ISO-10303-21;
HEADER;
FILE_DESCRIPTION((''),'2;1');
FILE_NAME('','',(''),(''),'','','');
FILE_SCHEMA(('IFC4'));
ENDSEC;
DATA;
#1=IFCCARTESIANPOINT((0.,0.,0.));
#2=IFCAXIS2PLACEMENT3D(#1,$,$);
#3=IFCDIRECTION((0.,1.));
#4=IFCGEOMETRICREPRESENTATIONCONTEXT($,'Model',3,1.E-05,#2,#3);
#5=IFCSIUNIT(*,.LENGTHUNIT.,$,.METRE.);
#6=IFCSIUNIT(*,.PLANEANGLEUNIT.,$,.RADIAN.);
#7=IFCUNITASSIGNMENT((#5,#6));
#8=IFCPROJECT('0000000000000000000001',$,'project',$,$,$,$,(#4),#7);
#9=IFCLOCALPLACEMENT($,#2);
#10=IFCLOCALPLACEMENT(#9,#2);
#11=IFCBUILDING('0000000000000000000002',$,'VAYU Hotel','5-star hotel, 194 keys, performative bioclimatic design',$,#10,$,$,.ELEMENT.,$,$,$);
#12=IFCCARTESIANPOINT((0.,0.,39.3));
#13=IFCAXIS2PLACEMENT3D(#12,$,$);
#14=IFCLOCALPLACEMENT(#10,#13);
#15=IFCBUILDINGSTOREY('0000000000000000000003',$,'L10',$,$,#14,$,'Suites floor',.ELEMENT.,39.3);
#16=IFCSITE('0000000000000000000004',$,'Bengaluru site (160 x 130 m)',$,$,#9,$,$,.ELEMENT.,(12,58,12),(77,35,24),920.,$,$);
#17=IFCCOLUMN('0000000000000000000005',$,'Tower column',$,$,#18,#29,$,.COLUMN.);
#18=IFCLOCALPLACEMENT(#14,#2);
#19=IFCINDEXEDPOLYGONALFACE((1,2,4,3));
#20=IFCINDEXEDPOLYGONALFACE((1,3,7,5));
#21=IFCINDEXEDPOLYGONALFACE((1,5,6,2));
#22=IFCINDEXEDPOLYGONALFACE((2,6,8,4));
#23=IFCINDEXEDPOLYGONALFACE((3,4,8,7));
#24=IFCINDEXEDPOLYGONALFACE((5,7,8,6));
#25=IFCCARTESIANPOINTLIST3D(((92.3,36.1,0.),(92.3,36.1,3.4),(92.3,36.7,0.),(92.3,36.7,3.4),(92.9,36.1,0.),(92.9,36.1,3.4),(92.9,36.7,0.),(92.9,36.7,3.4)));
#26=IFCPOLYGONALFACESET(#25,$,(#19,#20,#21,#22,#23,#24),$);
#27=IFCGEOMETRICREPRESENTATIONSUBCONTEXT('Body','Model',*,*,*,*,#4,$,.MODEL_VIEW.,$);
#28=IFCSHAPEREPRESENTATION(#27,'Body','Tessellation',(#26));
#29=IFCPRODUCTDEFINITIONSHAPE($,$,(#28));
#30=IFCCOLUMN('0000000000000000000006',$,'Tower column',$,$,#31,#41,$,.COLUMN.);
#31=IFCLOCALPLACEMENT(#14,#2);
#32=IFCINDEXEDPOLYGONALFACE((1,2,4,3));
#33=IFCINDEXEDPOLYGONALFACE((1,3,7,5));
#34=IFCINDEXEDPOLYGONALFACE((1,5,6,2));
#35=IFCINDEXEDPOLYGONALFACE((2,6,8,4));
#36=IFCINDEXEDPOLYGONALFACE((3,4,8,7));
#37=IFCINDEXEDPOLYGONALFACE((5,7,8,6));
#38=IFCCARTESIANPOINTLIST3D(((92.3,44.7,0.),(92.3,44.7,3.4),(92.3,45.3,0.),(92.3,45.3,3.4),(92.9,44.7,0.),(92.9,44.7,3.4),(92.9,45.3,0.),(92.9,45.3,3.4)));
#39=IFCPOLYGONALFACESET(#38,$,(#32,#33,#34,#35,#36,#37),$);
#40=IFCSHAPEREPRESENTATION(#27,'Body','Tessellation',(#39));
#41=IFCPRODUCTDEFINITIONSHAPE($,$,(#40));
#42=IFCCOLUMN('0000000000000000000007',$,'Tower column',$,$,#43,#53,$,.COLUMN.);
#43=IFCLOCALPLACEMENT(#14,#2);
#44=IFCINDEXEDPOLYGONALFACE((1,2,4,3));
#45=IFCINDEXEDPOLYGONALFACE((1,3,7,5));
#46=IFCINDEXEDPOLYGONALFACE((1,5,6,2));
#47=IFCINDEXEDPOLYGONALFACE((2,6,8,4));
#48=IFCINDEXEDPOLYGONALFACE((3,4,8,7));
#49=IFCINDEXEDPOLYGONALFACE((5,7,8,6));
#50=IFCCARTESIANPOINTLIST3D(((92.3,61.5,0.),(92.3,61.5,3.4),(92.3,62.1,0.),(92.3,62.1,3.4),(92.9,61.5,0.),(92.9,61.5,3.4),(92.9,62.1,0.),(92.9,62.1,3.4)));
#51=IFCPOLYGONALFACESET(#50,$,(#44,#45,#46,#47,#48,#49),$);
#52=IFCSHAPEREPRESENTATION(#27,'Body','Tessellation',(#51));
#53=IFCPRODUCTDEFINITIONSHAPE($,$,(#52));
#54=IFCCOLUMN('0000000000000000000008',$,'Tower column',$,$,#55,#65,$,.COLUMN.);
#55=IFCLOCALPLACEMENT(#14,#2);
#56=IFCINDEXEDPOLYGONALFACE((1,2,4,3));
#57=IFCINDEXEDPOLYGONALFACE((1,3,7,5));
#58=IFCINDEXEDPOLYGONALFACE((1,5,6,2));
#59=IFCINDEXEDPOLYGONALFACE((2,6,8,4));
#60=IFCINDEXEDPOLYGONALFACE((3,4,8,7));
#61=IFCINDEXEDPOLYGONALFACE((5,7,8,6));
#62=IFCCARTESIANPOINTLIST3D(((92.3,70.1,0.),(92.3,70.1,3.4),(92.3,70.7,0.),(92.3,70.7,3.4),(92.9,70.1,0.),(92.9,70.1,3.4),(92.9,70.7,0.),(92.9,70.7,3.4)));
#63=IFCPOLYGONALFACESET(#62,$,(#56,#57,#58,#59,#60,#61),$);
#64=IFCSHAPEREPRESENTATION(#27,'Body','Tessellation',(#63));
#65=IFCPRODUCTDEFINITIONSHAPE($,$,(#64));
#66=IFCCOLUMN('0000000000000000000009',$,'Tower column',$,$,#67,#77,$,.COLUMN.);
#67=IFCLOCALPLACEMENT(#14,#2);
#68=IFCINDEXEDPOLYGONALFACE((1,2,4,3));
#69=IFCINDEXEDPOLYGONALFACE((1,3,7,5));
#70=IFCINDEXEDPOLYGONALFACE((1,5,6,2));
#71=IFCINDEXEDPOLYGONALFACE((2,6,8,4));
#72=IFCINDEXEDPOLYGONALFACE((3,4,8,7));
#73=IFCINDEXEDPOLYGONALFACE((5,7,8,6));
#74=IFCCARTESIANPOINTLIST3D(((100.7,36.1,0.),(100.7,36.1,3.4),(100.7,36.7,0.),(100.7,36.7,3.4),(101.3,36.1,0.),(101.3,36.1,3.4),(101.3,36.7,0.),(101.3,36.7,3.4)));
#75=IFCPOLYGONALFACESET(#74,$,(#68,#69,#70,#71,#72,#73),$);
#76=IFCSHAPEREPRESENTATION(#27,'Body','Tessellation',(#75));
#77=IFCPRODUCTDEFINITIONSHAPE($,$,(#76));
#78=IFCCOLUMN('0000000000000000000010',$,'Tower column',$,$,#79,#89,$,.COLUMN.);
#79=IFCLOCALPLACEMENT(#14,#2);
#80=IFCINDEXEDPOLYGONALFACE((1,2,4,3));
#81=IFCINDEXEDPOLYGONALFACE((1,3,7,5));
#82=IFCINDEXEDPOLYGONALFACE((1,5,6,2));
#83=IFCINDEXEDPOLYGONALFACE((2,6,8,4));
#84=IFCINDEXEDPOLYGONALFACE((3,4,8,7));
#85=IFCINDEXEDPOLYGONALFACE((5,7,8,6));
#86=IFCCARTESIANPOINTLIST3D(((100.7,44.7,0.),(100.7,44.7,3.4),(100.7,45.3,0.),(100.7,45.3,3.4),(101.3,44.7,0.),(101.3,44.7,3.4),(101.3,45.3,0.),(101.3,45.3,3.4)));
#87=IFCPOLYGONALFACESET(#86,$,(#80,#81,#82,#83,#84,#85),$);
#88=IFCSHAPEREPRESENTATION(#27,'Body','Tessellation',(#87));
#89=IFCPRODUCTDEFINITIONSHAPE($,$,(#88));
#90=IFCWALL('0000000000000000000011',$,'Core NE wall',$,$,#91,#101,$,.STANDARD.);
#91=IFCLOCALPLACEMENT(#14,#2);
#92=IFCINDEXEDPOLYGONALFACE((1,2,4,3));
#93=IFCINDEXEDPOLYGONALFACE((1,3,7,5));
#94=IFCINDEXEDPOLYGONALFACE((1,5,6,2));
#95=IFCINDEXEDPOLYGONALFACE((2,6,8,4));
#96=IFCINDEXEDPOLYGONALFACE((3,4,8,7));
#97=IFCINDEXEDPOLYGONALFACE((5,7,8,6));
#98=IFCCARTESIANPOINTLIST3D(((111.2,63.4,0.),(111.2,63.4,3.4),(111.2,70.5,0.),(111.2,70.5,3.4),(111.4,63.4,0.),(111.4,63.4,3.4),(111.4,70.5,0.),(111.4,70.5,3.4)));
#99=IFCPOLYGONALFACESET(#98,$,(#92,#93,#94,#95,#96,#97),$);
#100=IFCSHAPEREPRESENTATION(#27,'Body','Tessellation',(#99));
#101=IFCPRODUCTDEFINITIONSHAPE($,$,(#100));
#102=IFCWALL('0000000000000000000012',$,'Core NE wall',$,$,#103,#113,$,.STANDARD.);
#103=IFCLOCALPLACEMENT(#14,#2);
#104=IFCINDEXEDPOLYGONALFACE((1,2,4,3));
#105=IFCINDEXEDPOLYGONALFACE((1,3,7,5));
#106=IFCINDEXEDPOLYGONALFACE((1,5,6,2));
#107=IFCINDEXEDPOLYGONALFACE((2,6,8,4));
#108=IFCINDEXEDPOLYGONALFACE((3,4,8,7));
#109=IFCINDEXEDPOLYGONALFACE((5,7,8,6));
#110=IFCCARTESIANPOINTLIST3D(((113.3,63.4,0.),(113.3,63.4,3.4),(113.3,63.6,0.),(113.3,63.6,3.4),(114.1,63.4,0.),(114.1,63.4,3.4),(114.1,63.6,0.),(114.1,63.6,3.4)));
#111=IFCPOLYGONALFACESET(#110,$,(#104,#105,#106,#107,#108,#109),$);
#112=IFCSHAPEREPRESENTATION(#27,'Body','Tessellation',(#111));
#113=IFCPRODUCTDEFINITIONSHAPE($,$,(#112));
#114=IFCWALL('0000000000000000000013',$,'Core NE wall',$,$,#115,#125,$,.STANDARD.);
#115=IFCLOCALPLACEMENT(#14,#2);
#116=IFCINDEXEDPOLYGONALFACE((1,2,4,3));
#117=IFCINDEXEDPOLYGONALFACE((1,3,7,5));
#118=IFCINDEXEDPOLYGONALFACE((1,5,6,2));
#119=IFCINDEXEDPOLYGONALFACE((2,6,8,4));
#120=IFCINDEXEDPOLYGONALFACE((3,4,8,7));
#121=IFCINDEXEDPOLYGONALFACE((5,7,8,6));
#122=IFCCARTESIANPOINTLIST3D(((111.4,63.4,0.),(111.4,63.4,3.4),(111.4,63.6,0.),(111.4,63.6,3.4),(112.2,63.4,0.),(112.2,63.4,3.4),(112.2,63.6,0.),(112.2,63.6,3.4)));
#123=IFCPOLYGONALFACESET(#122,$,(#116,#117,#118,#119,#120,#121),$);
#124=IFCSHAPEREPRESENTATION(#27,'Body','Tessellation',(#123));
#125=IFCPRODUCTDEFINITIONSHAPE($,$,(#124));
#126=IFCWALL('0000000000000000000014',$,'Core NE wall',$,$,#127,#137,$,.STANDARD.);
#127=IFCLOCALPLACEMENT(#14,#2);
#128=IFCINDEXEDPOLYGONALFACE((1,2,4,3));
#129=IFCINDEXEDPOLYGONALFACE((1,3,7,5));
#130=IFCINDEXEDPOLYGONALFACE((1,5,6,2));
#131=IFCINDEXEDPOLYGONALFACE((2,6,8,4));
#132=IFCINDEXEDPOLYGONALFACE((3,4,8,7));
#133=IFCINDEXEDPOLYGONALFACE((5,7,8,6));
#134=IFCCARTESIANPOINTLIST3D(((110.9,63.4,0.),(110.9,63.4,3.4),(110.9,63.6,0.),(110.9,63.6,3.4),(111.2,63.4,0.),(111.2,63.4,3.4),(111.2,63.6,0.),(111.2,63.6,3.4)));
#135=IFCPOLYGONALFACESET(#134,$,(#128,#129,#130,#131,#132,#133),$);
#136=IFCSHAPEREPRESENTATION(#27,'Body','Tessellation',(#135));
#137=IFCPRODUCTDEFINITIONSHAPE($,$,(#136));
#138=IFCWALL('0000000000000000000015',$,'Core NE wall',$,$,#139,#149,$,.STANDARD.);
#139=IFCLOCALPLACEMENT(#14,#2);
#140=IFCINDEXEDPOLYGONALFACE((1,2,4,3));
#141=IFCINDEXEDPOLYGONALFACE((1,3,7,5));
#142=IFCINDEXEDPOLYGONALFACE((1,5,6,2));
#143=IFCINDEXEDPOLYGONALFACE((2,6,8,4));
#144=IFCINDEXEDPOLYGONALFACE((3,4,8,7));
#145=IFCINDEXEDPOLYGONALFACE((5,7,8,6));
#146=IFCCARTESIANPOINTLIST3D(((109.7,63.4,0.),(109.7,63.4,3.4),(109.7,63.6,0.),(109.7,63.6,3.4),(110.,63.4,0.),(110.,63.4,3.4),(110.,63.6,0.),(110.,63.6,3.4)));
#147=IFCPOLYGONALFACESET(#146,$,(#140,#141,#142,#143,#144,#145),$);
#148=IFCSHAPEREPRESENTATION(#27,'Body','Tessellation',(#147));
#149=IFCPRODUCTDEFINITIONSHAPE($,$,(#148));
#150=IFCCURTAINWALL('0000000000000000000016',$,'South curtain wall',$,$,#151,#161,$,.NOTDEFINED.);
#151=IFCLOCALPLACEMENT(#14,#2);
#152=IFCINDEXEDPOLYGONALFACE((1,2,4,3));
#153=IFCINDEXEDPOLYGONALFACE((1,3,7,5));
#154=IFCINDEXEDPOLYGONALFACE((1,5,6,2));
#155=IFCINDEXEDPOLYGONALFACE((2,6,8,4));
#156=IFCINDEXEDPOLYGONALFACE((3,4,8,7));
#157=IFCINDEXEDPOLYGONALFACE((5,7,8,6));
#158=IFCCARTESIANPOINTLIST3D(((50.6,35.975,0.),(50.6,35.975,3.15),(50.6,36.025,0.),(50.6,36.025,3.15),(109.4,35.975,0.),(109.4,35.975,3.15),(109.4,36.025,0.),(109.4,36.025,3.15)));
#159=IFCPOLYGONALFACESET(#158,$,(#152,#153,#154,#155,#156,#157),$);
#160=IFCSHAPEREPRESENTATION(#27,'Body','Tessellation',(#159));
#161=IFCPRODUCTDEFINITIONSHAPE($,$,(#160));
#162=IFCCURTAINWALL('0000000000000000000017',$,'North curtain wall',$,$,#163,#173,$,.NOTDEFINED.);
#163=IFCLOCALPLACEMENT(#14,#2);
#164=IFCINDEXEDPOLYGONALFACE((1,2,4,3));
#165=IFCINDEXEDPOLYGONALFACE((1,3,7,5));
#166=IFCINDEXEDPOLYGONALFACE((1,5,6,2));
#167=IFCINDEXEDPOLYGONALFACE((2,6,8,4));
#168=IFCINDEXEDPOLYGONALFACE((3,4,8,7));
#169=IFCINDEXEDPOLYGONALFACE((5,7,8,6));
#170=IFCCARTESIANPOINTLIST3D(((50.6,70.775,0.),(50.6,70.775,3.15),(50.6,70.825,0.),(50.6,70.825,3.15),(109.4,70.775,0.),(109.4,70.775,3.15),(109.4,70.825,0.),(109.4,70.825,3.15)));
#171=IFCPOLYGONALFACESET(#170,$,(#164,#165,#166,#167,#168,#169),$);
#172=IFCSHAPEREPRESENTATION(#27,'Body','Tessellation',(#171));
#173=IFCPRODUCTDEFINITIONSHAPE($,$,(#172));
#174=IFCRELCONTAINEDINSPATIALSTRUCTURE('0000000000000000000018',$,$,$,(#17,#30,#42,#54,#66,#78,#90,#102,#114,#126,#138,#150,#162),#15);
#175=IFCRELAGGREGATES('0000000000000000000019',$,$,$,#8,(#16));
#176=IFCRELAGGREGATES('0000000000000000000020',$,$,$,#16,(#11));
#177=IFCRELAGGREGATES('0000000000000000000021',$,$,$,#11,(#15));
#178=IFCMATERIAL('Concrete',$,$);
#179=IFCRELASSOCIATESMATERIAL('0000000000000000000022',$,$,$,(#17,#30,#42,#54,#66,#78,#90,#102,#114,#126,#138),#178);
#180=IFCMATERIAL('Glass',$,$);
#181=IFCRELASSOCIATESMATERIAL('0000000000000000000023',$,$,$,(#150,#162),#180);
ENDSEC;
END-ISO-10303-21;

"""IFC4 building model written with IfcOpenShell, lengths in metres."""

from ifc_helpers import new_model, si_unit, direction, frame, origin, place, context, subcontext, project, spatial, polyline, outline, extrude, material, element, save


model = new_model("IFC4")

# Units and contexts
model_context = context("Model", 3, precision=1e-05, world=origin(), true_north=direction((0.0, 1.0)))
body_context = subcontext(model_context, "Body", "Model", "MODEL_VIEW")
ifc_project = project(units=[si_unit("LENGTHUNIT", "METRE"), si_unit("PLANEANGLEUNIT", "RADIAN")], contexts=[model_context])

# Site, building, storey
site_placement = place(None, origin())
site = spatial("IfcSite", under=ifc_project, at=site_placement, Name="Bengaluru site (160 x 130 m)", CompositionType="ELEMENT", RefLatitude=(12, 58, 12), RefLongitude=(77, 35, 24), RefElevation=920.0)
building_placement = place(site_placement, origin())
building = spatial("IfcBuilding", under=site, at=building_placement, Name="VAYU Hotel", Description="5-star hotel, 194 keys, performative bioclimatic design", CompositionType="ELEMENT")
storey_placement = place(building_placement, frame((0.0, 0.0, 39.3)))
storey = spatial("IfcBuildingStorey", under=building, at=storey_placement, Name="L10", LongName="Suites floor", CompositionType="ELEMENT", Elevation=39.3)

# Columns
ifc_material_1 = material(Name="Concrete")
column_1_placement = place(storey_placement, origin())
element("IfcColumn", 1, at=column_1_placement, inside=storey, material=ifc_material_1, Name="Tower column", PredefinedType="COLUMN", context=body_context, shape_type="SweptSolid", body=[
    extrude(outline(polyline([(92.3, 36.1), (92.9, 36.1), (92.9, 36.7), (92.3, 36.7), (92.3, 36.1)])), origin(), (0.0, 0.0, 1.0), 3.4),
])
column_2_placement = place(storey_placement, origin())
element("IfcColumn", 2, at=column_2_placement, inside=storey, material=ifc_material_1, Name="Tower column", PredefinedType="COLUMN", context=body_context, shape_type="SweptSolid", body=[
    extrude(outline(polyline([(92.3, 44.7), (92.9, 44.7), (92.9, 45.3), (92.3, 45.3), (92.3, 44.7)])), origin(), (0.0, 0.0, 1.0), 3.4),
])
column_3_placement = place(storey_placement, origin())
element("IfcColumn", 3, at=column_3_placement, inside=storey, material=ifc_material_1, Name="Tower column", PredefinedType="COLUMN", context=body_context, shape_type="SweptSolid", body=[
    extrude(outline(polyline([(92.3, 61.5), (92.9, 61.5), (92.9, 62.1), (92.3, 62.1), (92.3, 61.5)])), origin(), (0.0, 0.0, 1.0), 3.4),
])
column_4_placement = place(storey_placement, origin())
element("IfcColumn", 4, at=column_4_placement, inside=storey, material=ifc_material_1, Name="Tower column", PredefinedType="COLUMN", context=body_context, shape_type="SweptSolid", body=[
    extrude(outline(polyline([(92.3, 70.1), (92.9, 70.1), (92.9, 70.7), (92.3, 70.7), (92.3, 70.1)])), origin(), (0.0, 0.0, 1.0), 3.4),
])
column_5_placement = place(storey_placement, origin())
element("IfcColumn", 5, at=column_5_placement, inside=storey, material=ifc_material_1, Name="Tower column", PredefinedType="COLUMN", context=body_context, shape_type="SweptSolid", body=[
    extrude(outline(polyline([(100.7, 36.1), (101.3, 36.1), (101.3, 36.7), (100.7, 36.7), (100.7, 36.1)])), origin(), (0.0, 0.0, 1.0), 3.4),
])
column_6_placement = place(storey_placement, origin())
element("IfcColumn", 6, at=column_6_placement, inside=storey, material=ifc_material_1, Name="Tower column", PredefinedType="COLUMN", context=body_context, shape_type="SweptSolid", body=[
    extrude(outline(polyline([(100.7, 44.7), (101.3, 44.7), (101.3, 45.3), (100.7, 45.3), (100.7, 44.7)])), origin(), (0.0, 0.0, 1.0), 3.4),
])

# Walls
wall_1_placement = place(storey_placement, origin())
element("IfcWall", 7, at=wall_1_placement, inside=storey, material=ifc_material_1, Name="Core NE wall", PredefinedType="STANDARD", context=body_context, shape_type="SweptSolid", body=[
    extrude(outline(polyline([(111.2, 63.4), (111.2, 70.5), (111.4, 70.5), (111.4, 63.4), (111.2, 63.4)])), origin(), (0.0, 0.0, 1.0), 3.4),
])
wall_2_placement = place(storey_placement, origin())
element("IfcWall", 8, at=wall_2_placement, inside=storey, material=ifc_material_1, Name="Core NE wall", PredefinedType="STANDARD", context=body_context, shape_type="SweptSolid", body=[
    extrude(outline(polyline([(113.3, 63.6), (114.1, 63.6), (114.1, 63.4), (113.3, 63.4), (113.3, 63.6)])), origin(), (0.0, 0.0, 1.0), 3.4),
])
wall_3_placement = place(storey_placement, origin())
element("IfcWall", 9, at=wall_3_placement, inside=storey, material=ifc_material_1, Name="Core NE wall", PredefinedType="STANDARD", context=body_context, shape_type="SweptSolid", body=[
    extrude(outline(polyline([(111.4, 63.6), (112.2, 63.6), (112.2, 63.4), (111.4, 63.4), (111.4, 63.6)])), origin(), (0.0, 0.0, 1.0), 3.4),
])
wall_4_placement = place(storey_placement, origin())
element("IfcWall", 10, at=wall_4_placement, inside=storey, material=ifc_material_1, Name="Core NE wall", PredefinedType="STANDARD", context=body_context, shape_type="SweptSolid", body=[
    extrude(outline(polyline([(110.9, 63.6), (111.2, 63.6), (111.2, 63.4), (110.9, 63.4), (110.9, 63.6)])), origin(), (0.0, 0.0, 1.0), 3.4),
])
wall_5_placement = place(storey_placement, origin())
element("IfcWall", 11, at=wall_5_placement, inside=storey, material=ifc_material_1, Name="Core NE wall", PredefinedType="STANDARD", context=body_context, shape_type="SweptSolid", body=[
    extrude(outline(polyline([(109.7, 63.6), (110.0, 63.6), (110.0, 63.4), (109.7, 63.4), (109.7, 63.6)])), origin(), (0.0, 0.0, 1.0), 3.4),
])

# Curtain walls
ifc_material_2 = material(Name="Glass")
curtain_wall_1_placement = place(storey_placement, origin())
element("IfcCurtainWall", 12, at=curtain_wall_1_placement, inside=storey, material=ifc_material_2, Name="South curtain wall", PredefinedType="NOTDEFINED", context=body_context, shape_type="SweptSolid", body=[
    extrude(outline(polyline([(50.6, 36.025), (109.4, 36.025), (109.4, 35.975), (50.6, 35.975), (50.6, 36.025)])), origin(), (0.0, 0.0, 1.0), 3.15),
])
curtain_wall_2_placement = place(storey_placement, origin())
element("IfcCurtainWall", 13, at=curtain_wall_2_placement, inside=storey, material=ifc_material_2, Name="North curtain wall", PredefinedType="NOTDEFINED", context=body_context, shape_type="SweptSolid", body=[
    extrude(outline(polyline([(50.6, 70.825), (109.4, 70.825), (109.4, 70.775), (50.6, 70.775), (50.6, 70.825)])), origin(), (0.0, 0.0, 1.0), 3.15),
])

save(model, "model.ifc")
